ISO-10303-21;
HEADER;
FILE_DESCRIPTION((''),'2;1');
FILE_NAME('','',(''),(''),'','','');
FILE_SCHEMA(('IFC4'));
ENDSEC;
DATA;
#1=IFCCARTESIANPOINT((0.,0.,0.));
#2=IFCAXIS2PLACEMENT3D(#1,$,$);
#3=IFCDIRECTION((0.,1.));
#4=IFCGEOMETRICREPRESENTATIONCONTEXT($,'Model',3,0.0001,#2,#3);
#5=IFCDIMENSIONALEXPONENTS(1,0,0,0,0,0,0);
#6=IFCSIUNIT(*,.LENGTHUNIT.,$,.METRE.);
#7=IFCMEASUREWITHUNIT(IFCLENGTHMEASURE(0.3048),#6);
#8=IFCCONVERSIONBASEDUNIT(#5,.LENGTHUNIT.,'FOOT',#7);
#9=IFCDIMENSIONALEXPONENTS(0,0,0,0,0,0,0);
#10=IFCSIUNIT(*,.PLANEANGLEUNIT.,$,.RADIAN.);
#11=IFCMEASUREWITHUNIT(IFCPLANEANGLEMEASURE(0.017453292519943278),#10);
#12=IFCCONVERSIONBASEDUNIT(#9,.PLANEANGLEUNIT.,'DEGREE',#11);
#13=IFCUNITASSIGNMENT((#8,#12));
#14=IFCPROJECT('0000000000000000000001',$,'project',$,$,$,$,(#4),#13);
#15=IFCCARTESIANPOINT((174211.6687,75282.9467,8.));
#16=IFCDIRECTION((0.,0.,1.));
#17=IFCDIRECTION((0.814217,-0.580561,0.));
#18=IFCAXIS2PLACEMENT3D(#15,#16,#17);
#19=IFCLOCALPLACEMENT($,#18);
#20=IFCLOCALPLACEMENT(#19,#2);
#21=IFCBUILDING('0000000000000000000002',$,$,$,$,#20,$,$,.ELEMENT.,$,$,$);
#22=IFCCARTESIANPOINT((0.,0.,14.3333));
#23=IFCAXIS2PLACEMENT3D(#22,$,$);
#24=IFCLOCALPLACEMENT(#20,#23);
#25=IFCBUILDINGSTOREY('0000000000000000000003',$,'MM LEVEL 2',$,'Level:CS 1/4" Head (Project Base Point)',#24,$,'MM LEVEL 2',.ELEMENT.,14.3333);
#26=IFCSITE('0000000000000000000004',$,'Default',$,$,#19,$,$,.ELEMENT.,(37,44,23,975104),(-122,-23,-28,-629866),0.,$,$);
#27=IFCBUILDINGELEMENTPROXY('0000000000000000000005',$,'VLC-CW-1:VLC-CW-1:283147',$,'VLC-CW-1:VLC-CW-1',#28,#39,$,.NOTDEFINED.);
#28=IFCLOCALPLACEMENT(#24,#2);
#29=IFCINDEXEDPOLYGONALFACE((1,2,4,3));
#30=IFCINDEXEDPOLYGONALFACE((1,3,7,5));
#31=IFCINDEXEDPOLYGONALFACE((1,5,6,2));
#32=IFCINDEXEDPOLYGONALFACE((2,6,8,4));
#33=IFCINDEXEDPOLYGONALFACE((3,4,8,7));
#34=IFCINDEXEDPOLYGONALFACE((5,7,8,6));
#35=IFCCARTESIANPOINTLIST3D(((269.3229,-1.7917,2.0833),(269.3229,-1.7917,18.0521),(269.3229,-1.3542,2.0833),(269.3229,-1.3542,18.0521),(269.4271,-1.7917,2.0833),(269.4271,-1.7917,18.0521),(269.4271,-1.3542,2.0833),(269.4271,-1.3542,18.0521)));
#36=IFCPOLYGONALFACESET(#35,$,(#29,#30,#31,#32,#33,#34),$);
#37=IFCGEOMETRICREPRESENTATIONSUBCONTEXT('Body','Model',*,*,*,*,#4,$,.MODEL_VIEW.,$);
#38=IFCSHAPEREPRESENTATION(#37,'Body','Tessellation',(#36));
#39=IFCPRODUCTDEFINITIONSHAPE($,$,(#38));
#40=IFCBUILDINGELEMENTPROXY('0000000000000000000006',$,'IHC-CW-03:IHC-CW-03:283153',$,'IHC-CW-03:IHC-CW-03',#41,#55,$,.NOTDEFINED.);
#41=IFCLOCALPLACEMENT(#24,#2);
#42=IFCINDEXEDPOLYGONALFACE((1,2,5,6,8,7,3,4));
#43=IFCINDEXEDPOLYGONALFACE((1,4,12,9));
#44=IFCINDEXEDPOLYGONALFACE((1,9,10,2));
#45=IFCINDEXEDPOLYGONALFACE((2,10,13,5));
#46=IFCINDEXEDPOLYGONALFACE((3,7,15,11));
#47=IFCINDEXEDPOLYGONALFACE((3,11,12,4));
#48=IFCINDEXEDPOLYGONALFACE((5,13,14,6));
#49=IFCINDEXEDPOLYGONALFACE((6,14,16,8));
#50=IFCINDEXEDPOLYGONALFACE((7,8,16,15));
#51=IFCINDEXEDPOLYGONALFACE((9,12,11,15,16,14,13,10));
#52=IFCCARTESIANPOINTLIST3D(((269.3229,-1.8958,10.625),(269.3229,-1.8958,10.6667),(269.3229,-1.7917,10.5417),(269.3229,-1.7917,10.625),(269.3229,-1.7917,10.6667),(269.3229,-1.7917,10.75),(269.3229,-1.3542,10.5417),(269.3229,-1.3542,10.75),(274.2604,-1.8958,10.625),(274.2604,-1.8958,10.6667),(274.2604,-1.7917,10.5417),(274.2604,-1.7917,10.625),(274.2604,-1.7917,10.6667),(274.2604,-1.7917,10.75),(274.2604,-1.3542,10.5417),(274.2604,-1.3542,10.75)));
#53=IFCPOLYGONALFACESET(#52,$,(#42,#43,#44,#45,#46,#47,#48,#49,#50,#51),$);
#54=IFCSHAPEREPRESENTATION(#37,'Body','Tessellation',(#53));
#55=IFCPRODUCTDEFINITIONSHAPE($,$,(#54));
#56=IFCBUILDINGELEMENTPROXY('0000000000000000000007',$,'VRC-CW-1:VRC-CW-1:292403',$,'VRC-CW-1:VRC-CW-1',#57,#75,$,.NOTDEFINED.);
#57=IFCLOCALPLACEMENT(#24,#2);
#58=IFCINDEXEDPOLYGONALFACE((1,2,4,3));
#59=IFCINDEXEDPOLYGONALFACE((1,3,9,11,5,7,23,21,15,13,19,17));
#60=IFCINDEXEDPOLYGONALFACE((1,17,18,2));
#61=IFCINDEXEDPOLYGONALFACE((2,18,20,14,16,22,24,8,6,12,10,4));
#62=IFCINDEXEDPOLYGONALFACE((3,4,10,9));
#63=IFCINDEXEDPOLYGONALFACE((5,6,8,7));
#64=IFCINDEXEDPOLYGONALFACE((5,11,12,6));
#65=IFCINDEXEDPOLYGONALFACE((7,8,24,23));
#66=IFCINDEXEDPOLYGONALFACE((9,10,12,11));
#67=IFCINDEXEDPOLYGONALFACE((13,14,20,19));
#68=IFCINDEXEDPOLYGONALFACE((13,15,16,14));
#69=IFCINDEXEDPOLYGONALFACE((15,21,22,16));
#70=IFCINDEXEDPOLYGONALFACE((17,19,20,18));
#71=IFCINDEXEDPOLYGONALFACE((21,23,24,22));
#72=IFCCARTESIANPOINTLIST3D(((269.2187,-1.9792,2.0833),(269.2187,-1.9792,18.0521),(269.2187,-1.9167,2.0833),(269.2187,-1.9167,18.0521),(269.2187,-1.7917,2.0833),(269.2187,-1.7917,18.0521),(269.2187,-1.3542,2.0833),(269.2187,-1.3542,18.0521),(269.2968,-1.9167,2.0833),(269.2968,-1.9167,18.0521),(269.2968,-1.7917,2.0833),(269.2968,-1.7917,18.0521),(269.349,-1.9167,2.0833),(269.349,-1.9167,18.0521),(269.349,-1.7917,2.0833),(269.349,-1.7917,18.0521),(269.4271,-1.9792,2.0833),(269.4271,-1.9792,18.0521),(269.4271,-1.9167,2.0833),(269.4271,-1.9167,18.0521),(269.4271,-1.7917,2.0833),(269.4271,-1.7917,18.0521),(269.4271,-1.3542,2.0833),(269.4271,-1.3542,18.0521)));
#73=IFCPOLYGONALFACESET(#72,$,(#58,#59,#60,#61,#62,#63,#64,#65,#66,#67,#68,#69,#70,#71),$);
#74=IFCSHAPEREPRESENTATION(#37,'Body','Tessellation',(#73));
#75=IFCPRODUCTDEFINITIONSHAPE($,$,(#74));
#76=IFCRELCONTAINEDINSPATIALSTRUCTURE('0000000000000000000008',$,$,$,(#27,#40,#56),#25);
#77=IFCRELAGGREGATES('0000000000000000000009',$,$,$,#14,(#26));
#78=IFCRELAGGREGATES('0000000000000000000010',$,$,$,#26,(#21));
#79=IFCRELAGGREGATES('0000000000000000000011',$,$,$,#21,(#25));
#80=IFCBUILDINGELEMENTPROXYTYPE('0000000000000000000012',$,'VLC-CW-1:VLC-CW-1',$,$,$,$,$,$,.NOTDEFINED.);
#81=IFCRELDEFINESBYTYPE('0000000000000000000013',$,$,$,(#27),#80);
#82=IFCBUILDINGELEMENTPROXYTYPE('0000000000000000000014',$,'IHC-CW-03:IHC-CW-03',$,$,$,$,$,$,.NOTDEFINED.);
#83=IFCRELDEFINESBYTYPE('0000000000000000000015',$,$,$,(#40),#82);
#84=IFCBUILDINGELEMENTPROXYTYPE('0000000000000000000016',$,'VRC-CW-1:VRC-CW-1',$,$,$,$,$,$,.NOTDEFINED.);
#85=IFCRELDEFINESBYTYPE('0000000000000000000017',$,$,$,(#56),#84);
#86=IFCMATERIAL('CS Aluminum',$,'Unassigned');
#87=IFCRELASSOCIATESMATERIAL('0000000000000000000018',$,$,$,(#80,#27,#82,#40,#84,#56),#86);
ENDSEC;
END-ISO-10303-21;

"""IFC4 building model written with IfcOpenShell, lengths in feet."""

from ifc_helpers import new_model, entity, si_unit, converted_unit, direction, frame, origin, place, context, subcontext, project, spatial, indexed_curve, outline, extrude, source, transform, mapped, material, type_object, type_shapes, element, save


model = new_model("IFC4")

# Units and contexts
model_context = context("Model", 3, precision=0.0001, world=origin(), true_north=direction((0.0, 1.0)))
body_context = subcontext(model_context, "Body", "Model", "MODEL_VIEW")
ifc_project = project(units=[converted_unit("LENGTHUNIT", "FOOT", entity("IfcLengthMeasure", 0.3048), si_unit("LENGTHUNIT", "METRE"), dimensions=[1, 0, 0, 0, 0, 0, 0]), converted_unit("PLANEANGLEUNIT", "DEGREE", entity("IfcPlaneAngleMeasure", 0.017453292519943278), si_unit("PLANEANGLEUNIT", "RADIAN"), dimensions=[0, 0, 0, 0, 0, 0, 0])], contexts=[model_context])

# Site, building, storey
site_placement = place(None, frame((174211.6687, 75282.9467, 8.0), z_axis=(0.0, 0.0, 1.0), x_axis=(0.814217, -0.580561, 0.0)))
site = spatial("IfcSite", under=ifc_project, at=site_placement, Name="Default", CompositionType="ELEMENT", RefLatitude=(37, 44, 23, 975104), RefLongitude=(-122, -23, -28, -629866), RefElevation=0.0)
building_placement = place(site_placement, origin())
building = spatial("IfcBuilding", under=site, at=building_placement, CompositionType="ELEMENT")
storey_placement = place(building_placement, frame((0.0, 0.0, 14.3333)))
storey = spatial("IfcBuildingStorey", under=building, at=storey_placement, Name="MM LEVEL 2", ObjectType="Level:CS 1/4\" Head (Project Base Point)", LongName="MM LEVEL 2", CompositionType="ELEMENT", Elevation=14.3333)

# Shared definitions
ifc_material_1 = material(Name="CS Aluminum", Category="Unassigned")

# Building element proxies
building_element_proxy_type_1 = type_object("IfcBuildingElementProxyType", Name="VLC-CW-1:VLC-CW-1", PredefinedType="NOTDEFINED", material=ifc_material_1)
shared_shape_1 = source(origin(), body_context, "Body", "SweptSolid", [
    extrude(outline(indexed_curve([(-0.2187, -0.0521), (0.2187, -0.0521), (0.2187, 0.0521), (-0.2187, 0.0521), (-0.2187, -0.0521)], self_intersect=False)), frame((0.0521, 0.4062, 0.0), z_axis=(0.0, 0.0, 1.0), x_axis=(0.0, -1.0, 0.0)), (0.0, 0.0, 1.0), 15.9687),
])
type_shapes(building_element_proxy_type_1, [shared_shape_1])
proxy_1_placement = place(storey_placement, frame((269.3229, -1.9792, 2.0833)))
element("IfcBuildingElementProxy", 1, at=proxy_1_placement, inside=storey, type_object=building_element_proxy_type_1, material=ifc_material_1, Name="VLC-CW-1:VLC-CW-1:283147", ObjectType="VLC-CW-1:VLC-CW-1", PredefinedType="NOTDEFINED", context=body_context, shape_type="MappedRepresentation", body=[
    mapped(shared_shape_1, transform((0.0, 0.0, 0.0), scale=1.0)),
])
building_element_proxy_type_2 = type_object("IfcBuildingElementProxyType", Name="IHC-CW-03:IHC-CW-03", PredefinedType="NOTDEFINED", material=ifc_material_1)
shared_shape_2 = source(origin(), body_context, "Body", "SweptSolid", [
    extrude(outline(indexed_curve([(-0.0208, -0.1875), (0.0208, -0.1875), (0.0208, -0.0833), (0.1042, -0.0833), (0.1042, 0.3542), (-0.1042, 0.3542), (-0.1042, -0.0833), (-0.0208, -0.0833), (-0.0208, -0.1875)], self_intersect=False)), frame((-2.4688, -0.2708, -0.1042), z_axis=(1.0, 0.0, 0.0), x_axis=(0.0, 0.0, 1.0)), (0.0, 0.0, 1.0), 4.9375),
])
type_shapes(building_element_proxy_type_2, [shared_shape_2])
proxy_2_placement = place(storey_placement, frame((271.7917, -1.9792, 10.75), z_axis=(0.0, 0.0, 1.0), x_axis=(-1.0, 0.0, 0.0)))
element("IfcBuildingElementProxy", 2, at=proxy_2_placement, inside=storey, type_object=building_element_proxy_type_2, material=ifc_material_1, Name="IHC-CW-03:IHC-CW-03:283153", ObjectType="IHC-CW-03:IHC-CW-03", PredefinedType="NOTDEFINED", context=body_context, shape_type="MappedRepresentation", body=[
    mapped(shared_shape_2, transform((0.0, 0.0, 0.0), scale=1.0)),
])
building_element_proxy_type_3 = type_object("IfcBuildingElementProxyType", Name="VRC-CW-1:VRC-CW-1", PredefinedType="NOTDEFINED", material=ifc_material_1)
shared_shape_3 = source(origin(), body_context, "Body", "SweptSolid", [
    extrude(outline(indexed_curve([(-0.1042, -0.4375), (0.1042, -0.4375), (0.1042, 0.0), (0.0261, 0.0), (0.0261, 0.125), (0.1042, 0.125), (0.1042, 0.1875), (-0.1042, 0.1875), (-0.1042, 0.125), (-0.0261, 0.125), (-0.0261, 0.0), (-0.1042, 0.0), (-0.1042, -0.4375)], self_intersect=False)), frame((0.0, 0.1875, 0.0), z_axis=(0.0, 0.0, 1.0), x_axis=(-1.0, 0.0, 0.0)), (0.0, 0.0, 1.0), 15.9687),
])
type_shapes(building_element_proxy_type_3, [shared_shape_3])
proxy_3_placement = place(storey_placement, frame((269.3229, -1.9792, 2.0833)))
element("IfcBuildingElementProxy", 3, at=proxy_3_placement, inside=storey, type_object=building_element_proxy_type_3, material=ifc_material_1, Name="VRC-CW-1:VRC-CW-1:292403", ObjectType="VRC-CW-1:VRC-CW-1", PredefinedType="NOTDEFINED", context=body_context, shape_type="MappedRepresentation", body=[
    mapped(shared_shape_3, transform((0.0, 0.0, 0.0), scale=1.0)),
])

save(model, "model.ifc")
